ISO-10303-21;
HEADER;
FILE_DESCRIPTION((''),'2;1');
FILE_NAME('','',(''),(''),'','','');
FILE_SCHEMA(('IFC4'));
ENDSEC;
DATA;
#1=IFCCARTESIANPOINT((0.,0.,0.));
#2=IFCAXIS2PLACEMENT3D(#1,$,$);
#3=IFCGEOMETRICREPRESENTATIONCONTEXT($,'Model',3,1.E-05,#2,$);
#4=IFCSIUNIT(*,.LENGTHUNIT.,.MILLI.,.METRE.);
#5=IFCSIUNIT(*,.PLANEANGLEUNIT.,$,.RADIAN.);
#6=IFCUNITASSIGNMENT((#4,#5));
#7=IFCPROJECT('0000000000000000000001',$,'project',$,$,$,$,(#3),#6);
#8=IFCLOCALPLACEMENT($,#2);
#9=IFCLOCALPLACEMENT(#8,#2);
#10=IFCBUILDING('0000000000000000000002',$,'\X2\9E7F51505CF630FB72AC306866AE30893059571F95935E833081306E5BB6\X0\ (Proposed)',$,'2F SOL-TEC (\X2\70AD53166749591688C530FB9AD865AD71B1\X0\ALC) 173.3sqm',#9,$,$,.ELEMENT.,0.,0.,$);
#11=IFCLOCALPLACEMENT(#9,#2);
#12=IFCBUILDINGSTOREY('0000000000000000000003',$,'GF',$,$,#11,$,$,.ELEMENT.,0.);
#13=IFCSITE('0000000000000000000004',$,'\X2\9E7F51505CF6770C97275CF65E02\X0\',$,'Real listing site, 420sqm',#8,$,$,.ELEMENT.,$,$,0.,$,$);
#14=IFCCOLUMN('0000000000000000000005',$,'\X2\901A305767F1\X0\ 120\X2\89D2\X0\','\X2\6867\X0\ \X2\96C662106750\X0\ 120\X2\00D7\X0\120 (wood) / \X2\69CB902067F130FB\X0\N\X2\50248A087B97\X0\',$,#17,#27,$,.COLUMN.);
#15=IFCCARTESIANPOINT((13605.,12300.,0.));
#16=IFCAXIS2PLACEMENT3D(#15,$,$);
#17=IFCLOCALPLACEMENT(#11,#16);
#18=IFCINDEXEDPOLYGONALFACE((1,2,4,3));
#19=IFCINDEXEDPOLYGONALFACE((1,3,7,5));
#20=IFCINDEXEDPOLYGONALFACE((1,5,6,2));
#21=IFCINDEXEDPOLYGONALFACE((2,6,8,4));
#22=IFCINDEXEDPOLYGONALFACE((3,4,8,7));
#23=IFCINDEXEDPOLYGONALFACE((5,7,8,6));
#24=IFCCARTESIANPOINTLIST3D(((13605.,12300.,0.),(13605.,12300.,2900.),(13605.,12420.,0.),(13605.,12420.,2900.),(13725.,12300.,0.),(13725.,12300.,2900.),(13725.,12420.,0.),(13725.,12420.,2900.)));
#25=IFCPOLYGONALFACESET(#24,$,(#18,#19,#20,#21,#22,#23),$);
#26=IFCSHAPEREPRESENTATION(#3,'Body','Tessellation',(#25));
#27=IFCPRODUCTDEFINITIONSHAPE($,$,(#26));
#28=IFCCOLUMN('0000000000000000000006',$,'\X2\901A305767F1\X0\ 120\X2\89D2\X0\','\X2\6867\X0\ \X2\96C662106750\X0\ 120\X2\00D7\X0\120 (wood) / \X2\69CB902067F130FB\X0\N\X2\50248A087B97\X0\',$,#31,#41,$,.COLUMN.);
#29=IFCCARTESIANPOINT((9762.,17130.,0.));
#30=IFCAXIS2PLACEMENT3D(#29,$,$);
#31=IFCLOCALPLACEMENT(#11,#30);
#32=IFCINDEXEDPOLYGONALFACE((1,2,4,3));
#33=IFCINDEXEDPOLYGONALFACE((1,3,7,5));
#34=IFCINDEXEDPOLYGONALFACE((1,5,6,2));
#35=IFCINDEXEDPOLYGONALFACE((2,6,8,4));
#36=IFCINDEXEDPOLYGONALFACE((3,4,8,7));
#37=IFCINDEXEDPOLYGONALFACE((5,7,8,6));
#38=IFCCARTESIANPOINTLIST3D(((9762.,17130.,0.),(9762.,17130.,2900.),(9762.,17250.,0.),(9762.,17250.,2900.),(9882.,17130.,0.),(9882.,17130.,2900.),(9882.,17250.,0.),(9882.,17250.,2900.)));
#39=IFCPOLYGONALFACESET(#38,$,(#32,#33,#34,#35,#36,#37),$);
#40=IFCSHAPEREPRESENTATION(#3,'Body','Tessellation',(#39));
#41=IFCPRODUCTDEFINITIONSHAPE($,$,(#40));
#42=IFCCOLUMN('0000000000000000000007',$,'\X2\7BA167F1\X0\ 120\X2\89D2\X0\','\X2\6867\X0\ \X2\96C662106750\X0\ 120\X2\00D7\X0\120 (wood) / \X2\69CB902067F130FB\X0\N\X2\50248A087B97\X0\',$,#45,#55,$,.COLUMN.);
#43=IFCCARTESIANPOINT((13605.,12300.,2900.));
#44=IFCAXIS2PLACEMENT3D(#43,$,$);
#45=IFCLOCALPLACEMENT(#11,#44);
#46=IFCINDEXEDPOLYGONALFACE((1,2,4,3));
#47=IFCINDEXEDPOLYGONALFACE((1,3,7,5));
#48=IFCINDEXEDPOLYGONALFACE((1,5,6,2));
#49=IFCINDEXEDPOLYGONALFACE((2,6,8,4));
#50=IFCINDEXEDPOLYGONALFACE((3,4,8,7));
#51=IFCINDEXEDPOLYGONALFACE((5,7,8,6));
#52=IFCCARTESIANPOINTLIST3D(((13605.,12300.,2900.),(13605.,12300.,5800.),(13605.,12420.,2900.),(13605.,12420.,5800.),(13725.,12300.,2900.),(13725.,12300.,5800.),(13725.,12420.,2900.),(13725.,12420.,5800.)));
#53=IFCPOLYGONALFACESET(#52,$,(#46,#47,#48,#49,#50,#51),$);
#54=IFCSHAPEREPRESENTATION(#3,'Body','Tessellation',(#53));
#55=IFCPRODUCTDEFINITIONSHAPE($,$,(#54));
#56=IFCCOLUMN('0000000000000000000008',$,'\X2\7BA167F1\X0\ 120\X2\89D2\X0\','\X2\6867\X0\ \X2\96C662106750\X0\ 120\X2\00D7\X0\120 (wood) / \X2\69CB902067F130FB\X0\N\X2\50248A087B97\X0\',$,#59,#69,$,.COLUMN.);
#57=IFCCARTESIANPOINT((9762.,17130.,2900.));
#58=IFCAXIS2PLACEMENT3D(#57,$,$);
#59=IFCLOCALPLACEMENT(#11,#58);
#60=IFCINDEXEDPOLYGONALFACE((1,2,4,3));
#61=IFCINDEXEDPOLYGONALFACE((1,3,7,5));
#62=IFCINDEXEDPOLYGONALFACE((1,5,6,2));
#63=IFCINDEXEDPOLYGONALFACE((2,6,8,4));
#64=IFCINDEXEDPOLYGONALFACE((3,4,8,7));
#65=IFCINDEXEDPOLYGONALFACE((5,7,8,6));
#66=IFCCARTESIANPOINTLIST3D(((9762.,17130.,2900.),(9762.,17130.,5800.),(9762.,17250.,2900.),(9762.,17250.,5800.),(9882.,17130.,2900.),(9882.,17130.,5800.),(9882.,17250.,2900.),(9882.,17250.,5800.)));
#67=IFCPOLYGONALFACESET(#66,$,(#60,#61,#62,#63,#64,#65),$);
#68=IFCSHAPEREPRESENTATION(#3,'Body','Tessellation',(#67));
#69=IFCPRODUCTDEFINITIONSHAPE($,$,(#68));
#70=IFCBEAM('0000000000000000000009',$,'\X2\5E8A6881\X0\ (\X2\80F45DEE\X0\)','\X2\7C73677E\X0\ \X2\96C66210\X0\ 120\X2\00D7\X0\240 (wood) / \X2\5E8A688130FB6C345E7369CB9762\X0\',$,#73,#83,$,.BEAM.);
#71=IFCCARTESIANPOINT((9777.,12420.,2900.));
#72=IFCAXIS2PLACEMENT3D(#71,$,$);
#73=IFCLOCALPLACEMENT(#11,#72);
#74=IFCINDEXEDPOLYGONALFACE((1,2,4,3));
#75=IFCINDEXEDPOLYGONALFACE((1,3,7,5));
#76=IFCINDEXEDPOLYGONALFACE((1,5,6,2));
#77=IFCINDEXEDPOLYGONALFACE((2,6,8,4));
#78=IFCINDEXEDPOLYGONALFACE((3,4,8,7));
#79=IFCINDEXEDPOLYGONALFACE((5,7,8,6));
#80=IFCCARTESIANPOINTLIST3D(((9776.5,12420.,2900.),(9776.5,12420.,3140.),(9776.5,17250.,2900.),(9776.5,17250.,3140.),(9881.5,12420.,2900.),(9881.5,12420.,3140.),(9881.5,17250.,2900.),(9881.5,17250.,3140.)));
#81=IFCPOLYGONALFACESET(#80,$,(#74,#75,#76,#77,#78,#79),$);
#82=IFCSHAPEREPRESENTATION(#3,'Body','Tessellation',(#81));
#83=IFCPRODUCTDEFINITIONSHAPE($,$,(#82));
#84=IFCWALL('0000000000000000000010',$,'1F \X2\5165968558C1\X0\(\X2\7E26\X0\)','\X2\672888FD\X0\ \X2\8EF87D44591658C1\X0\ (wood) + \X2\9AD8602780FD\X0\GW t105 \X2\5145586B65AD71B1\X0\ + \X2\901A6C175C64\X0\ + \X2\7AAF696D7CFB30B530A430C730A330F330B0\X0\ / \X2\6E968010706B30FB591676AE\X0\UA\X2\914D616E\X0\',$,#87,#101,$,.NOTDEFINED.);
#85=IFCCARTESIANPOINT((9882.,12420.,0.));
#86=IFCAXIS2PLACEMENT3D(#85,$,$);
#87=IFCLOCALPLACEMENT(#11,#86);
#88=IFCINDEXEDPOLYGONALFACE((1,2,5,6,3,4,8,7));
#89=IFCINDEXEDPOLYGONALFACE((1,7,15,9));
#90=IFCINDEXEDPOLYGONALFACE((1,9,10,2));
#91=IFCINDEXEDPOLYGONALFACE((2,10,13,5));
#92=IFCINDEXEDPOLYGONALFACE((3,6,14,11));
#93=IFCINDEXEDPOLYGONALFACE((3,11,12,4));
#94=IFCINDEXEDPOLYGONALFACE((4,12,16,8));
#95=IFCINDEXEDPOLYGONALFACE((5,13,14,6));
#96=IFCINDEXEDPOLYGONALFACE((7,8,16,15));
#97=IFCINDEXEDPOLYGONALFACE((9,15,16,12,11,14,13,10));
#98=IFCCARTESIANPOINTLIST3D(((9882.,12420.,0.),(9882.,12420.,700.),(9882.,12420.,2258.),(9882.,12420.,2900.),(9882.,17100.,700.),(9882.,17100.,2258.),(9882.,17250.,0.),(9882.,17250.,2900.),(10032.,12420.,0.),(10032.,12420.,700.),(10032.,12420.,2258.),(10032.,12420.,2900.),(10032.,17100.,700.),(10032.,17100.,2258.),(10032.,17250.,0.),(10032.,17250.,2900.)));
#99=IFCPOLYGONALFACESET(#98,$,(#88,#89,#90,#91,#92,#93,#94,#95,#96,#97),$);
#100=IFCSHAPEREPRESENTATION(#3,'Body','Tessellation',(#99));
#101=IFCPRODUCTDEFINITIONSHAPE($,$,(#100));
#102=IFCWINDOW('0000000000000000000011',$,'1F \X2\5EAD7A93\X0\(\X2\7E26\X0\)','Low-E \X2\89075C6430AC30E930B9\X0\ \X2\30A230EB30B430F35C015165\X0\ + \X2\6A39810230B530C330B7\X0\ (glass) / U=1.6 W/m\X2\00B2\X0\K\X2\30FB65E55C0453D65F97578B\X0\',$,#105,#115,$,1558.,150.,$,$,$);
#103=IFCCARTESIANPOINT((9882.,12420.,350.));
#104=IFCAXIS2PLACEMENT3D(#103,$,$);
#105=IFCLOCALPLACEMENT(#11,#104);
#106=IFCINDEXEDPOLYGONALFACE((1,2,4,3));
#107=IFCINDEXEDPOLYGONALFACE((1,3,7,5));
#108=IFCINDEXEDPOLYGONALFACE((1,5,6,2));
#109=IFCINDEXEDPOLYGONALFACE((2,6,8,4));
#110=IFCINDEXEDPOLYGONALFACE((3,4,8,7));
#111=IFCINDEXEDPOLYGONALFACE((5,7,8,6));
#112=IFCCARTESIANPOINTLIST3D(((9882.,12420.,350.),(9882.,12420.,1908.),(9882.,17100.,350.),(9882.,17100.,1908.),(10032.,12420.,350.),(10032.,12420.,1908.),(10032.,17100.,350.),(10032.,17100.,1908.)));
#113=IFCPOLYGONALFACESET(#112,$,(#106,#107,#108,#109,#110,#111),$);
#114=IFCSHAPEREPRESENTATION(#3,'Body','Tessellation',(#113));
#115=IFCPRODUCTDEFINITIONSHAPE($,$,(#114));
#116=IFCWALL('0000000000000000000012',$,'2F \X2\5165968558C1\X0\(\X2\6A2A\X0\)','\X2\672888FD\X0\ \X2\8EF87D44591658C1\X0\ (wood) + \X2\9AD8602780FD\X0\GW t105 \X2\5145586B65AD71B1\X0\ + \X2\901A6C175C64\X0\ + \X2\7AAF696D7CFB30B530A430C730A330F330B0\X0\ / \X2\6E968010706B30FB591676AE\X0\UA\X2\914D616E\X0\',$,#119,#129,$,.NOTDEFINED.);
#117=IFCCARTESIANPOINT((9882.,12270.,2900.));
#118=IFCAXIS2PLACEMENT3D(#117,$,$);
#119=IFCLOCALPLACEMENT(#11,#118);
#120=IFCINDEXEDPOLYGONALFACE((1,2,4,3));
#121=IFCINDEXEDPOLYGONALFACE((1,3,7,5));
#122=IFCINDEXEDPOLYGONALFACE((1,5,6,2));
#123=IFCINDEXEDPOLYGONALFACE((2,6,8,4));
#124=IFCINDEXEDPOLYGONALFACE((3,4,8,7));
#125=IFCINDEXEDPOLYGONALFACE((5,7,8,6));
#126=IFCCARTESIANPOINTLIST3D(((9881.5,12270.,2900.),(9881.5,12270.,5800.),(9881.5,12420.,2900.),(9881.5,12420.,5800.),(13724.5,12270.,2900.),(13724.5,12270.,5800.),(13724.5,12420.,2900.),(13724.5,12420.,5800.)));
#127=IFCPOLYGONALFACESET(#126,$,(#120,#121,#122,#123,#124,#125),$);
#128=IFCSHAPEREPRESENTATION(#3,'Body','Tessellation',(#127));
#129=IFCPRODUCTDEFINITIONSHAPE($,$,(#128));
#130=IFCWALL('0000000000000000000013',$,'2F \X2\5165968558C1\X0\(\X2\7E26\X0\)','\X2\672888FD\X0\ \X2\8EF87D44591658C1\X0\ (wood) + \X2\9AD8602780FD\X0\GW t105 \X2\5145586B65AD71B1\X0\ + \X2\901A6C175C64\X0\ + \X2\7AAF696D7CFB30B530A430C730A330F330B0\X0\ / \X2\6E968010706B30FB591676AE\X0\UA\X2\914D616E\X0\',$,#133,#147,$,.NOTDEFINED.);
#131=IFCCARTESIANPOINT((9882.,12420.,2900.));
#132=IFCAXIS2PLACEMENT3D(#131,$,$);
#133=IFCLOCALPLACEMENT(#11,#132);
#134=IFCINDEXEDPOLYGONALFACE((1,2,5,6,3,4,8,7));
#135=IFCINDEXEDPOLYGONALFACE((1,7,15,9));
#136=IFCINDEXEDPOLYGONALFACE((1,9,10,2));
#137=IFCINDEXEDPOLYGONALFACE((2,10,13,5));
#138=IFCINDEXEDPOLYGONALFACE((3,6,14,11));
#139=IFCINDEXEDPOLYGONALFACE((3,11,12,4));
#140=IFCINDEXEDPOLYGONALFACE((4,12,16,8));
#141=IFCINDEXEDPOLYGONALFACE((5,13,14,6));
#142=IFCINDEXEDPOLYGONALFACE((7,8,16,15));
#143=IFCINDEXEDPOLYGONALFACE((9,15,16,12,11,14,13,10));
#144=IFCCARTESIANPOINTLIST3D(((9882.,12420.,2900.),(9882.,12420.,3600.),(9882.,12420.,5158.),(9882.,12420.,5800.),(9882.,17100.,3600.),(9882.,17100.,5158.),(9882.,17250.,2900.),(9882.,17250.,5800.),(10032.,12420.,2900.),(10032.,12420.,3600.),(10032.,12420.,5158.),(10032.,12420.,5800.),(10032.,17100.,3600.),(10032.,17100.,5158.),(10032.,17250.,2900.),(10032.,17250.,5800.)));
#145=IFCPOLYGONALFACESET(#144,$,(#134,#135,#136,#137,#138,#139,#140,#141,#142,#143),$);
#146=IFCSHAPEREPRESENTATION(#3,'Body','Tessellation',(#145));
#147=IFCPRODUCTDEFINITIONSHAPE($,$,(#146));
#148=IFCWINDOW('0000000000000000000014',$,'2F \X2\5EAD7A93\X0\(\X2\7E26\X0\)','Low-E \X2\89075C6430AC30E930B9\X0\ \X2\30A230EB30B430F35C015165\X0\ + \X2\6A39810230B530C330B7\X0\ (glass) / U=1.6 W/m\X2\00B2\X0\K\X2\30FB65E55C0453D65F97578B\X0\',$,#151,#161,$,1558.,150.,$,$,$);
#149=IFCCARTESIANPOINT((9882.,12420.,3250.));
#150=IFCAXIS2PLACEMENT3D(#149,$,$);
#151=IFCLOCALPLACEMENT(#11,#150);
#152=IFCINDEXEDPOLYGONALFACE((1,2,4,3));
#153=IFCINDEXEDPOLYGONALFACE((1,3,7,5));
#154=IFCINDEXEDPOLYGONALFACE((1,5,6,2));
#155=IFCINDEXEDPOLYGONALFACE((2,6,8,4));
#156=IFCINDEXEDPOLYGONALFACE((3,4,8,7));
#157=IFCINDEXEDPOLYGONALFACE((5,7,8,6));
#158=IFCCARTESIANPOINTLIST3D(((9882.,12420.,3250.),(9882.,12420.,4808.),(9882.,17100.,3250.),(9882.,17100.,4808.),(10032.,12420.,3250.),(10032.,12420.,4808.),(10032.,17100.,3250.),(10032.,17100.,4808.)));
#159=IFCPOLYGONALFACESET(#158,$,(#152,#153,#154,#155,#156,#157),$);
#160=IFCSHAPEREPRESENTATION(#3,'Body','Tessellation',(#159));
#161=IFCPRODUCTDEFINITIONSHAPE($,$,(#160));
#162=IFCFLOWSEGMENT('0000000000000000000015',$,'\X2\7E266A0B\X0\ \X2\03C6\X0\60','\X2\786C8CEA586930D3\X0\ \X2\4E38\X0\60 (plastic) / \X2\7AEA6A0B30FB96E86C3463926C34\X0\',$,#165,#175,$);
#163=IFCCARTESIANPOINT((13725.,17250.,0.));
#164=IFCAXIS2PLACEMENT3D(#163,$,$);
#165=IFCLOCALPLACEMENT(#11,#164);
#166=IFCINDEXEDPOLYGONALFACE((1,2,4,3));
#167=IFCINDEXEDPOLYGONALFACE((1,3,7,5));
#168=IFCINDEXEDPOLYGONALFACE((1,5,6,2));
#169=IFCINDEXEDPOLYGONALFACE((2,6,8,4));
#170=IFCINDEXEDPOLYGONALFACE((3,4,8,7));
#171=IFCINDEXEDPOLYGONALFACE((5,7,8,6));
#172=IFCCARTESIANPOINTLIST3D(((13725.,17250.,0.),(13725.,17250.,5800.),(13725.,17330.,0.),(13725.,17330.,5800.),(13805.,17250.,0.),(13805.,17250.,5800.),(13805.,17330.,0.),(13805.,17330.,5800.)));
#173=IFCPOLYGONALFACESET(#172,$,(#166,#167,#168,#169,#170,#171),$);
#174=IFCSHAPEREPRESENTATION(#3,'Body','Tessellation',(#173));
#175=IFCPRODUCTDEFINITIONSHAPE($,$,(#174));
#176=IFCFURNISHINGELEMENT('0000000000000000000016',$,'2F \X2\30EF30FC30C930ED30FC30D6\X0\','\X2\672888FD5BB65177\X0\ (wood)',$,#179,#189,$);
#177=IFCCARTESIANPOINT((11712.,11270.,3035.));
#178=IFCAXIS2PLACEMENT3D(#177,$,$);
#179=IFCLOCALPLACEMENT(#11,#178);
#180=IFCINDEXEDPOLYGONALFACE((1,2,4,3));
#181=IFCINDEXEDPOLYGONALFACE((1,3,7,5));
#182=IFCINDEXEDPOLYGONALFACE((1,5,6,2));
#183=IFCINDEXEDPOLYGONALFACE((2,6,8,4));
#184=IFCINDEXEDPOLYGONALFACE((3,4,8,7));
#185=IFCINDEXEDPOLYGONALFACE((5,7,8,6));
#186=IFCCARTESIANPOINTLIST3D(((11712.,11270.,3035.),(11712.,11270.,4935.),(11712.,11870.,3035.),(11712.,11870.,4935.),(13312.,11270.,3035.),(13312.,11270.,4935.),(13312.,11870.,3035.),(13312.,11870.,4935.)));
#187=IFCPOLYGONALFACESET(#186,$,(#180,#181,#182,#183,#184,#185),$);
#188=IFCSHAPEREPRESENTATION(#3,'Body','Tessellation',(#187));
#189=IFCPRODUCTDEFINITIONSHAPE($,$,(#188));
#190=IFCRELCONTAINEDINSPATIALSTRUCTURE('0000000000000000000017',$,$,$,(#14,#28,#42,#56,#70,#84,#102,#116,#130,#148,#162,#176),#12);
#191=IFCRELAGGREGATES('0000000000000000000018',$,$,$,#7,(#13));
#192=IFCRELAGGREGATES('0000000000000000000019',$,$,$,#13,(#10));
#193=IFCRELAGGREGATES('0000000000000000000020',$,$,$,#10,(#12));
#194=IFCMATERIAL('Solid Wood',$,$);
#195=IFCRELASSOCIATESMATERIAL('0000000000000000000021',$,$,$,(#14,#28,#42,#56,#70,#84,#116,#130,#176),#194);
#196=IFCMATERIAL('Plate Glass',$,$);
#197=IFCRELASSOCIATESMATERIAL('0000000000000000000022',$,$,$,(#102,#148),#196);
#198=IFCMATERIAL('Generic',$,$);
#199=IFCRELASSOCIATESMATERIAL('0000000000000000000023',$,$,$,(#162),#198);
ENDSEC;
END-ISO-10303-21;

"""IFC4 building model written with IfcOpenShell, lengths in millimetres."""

from ifc_helpers import new_model, si_unit, frame, frame_2d, origin, place, context, project, spatial, rectangle, extrude, material, element, fill, save


model = new_model("IFC4")

# Units and contexts
model_context = context("Model", 3, precision=1e-05, world=origin())
ifc_project = project(units=[si_unit("LENGTHUNIT", "METRE", prefix="MILLI"), si_unit("PLANEANGLEUNIT", "RADIAN")], contexts=[model_context])

# Site, building, storey
site_placement = place(None, origin())
site = spatial("IfcSite", under=ifc_project, at=site_placement, Name="鹿児島県霧島市", ObjectType="Real listing site, 420sqm", CompositionType="ELEMENT", RefElevation=0.0)
building_placement = place(site_placement, origin())
building = spatial("IfcBuilding", under=site, at=building_placement, Name="鹿児島・犬と暮らす土間広めの家 (Proposed)", ObjectType="2F SOL-TEC (炭化杉外装・高断熱ALC) 173.3sqm", CompositionType="ELEMENT", ElevationOfRefHeight=0.0, ElevationOfTerrain=0.0)
storey_placement = place(building_placement, origin())
storey = spatial("IfcBuildingStorey", under=building, at=storey_placement, Name="GF", CompositionType="ELEMENT", Elevation=0.0)

# Columns
ifc_material_1 = material(Name="Solid Wood")
column_1_placement = place(storey_placement, frame((13605.0, 12300.0, 0.0)))
element("IfcColumn", 1, at=column_1_placement, inside=storey, material=ifc_material_1, Name="通し柱 120角", Description="桧 集成材 120×120 (wood) / 構造柱・N値計算", PredefinedType="COLUMN", context=model_context, shape_type="SweptSolid", body=[
    extrude(rectangle(XDim=120.0, YDim=120.0, at=frame_2d((60.0, 60.0))), frame((13605.0, 12300.0, 0.0)), (0.0, 0.0, 1.0), 2900.0),
])
column_2_placement = place(storey_placement, frame((9762.0, 17130.0, 0.0)))
element("IfcColumn", 2, at=column_2_placement, inside=storey, material=ifc_material_1, Name="通し柱 120角", Description="桧 集成材 120×120 (wood) / 構造柱・N値計算", PredefinedType="COLUMN", context=model_context, shape_type="SweptSolid", body=[
    extrude(rectangle(XDim=120.0, YDim=120.0, at=frame_2d((60.0, 60.0))), frame((9762.0, 17130.0, 0.0)), (0.0, 0.0, 1.0), 2900.0),
])
column_3_placement = place(storey_placement, frame((13605.0, 12300.0, 2900.0)))
element("IfcColumn", 3, at=column_3_placement, inside=storey, material=ifc_material_1, Name="管柱 120角", Description="桧 集成材 120×120 (wood) / 構造柱・N値計算", PredefinedType="COLUMN", context=model_context, shape_type="SweptSolid", body=[
    extrude(rectangle(XDim=120.0, YDim=120.0, at=frame_2d((60.0, 60.0))), frame((13605.0, 12300.0, 2900.0)), (0.0, 0.0, 1.0), 2900.0),
])
column_4_placement = place(storey_placement, frame((9762.0, 17130.0, 2900.0)))
element("IfcColumn", 4, at=column_4_placement, inside=storey, material=ifc_material_1, Name="管柱 120角", Description="桧 集成材 120×120 (wood) / 構造柱・N値計算", PredefinedType="COLUMN", context=model_context, shape_type="SweptSolid", body=[
    extrude(rectangle(XDim=120.0, YDim=120.0, at=frame_2d((60.0, 60.0))), frame((9762.0, 17130.0, 2900.0)), (0.0, 0.0, 1.0), 2900.0),
])

# Beam
beam_1_placement = place(storey_placement, frame((9777.0, 12420.0, 2900.0)))
element("IfcBeam", 5, at=beam_1_placement, inside=storey, material=ifc_material_1, Name="床梁 (胴差)", Description="米松 集成 120×240 (wood) / 床梁・水平構面", PredefinedType="BEAM", context=model_context, shape_type="SweptSolid", body=[
    extrude(rectangle(XDim=105.0, YDim=4830.0, at=frame_2d((52.0, 2415.0))), frame((9777.0, 12420.0, 2900.0)), (0.0, 0.0, 1.0), 240.0),
])

# Wall, opening, window
wall_1_placement = place(storey_placement, frame((9882.0, 12420.0, 0.0)))
wall_1 = element("IfcWall", 6, at=wall_1_placement, inside=storey, material=ifc_material_1, Name="1F 入隅壁(縦)", Description="木製 軸組外壁 (wood) + 高性能GW t105 充填断熱 + 通気層 + 窯業系サイディング / 準耐火・外皮UA配慮", PredefinedType="NOTDEFINED", context=model_context, shape_type="SweptSolid", body=[
    extrude(rectangle(XDim=150.0, YDim=4830.0, at=frame_2d((75.0, 2415.0))), frame((9882.0, 12420.0, 0.0)), (0.0, 0.0, 1.0), 2900.0),
])
opening_1_placement = place(storey_placement, frame((9882.0, 12420.0, 350.0)))
opening_1 = element("IfcOpeningElement", 7, at=opening_1_placement, cuts=wall_1, PredefinedType="NOTDEFINED", context=model_context, shape_type="SweptSolid", body=[
    extrude(rectangle(XDim=150.0, YDim=4680.0, at=frame_2d((75.0, 2340.0))), frame((9882.0, 12420.0, 350.0)), (0.0, 0.0, 1.0), 1558.0),
])
ifc_material_2 = material(Name="Plate Glass")
window_1_placement = place(storey_placement, frame((9882.0, 12420.0, 350.0)))
window_1 = element("IfcWindow", 8, at=window_1_placement, inside=storey, material=ifc_material_2, Name="1F 庭窓(縦)", Description="Low-E 複層ガラス アルゴン封入 + 樹脂サッシ (glass) / U=1.6 W/m²K・日射取得型", OverallHeight=1558.0, OverallWidth=150.0, context=model_context, shape_type="SweptSolid", body=[
    extrude(rectangle(XDim=150.0, YDim=4680.0, at=frame_2d((75.0, 2340.0))), frame((9882.0, 12420.0, 350.0)), (0.0, 0.0, 1.0), 1558.0),
])
fill(opening_1, window_1)

# Wall
wall_2_placement = place(storey_placement, frame((9882.0, 12270.0, 2900.0)))
element("IfcWall", 9, at=wall_2_placement, inside=storey, material=ifc_material_1, Name="2F 入隅壁(横)", Description="木製 軸組外壁 (wood) + 高性能GW t105 充填断熱 + 通気層 + 窯業系サイディング / 準耐火・外皮UA配慮", PredefinedType="NOTDEFINED", context=model_context, shape_type="SweptSolid", body=[
    extrude(rectangle(XDim=3843.0, YDim=150.0, at=frame_2d((1921.0, 75.0))), frame((9882.0, 12270.0, 2900.0)), (0.0, 0.0, 1.0), 2900.0),
])

# Wall, opening, window
wall_3_placement = place(storey_placement, frame((9882.0, 12420.0, 2900.0)))
wall_3 = element("IfcWall", 10, at=wall_3_placement, inside=storey, material=ifc_material_1, Name="2F 入隅壁(縦)", Description="木製 軸組外壁 (wood) + 高性能GW t105 充填断熱 + 通気層 + 窯業系サイディング / 準耐火・外皮UA配慮", PredefinedType="NOTDEFINED", context=model_context, shape_type="SweptSolid", body=[
    extrude(rectangle(XDim=150.0, YDim=4830.0, at=frame_2d((75.0, 2415.0))), frame((9882.0, 12420.0, 2900.0)), (0.0, 0.0, 1.0), 2900.0),
])
opening_2_placement = place(storey_placement, frame((9882.0, 12420.0, 3250.0)))
opening_2 = element("IfcOpeningElement", 11, at=opening_2_placement, cuts=wall_3, PredefinedType="NOTDEFINED", context=model_context, shape_type="SweptSolid", body=[
    extrude(rectangle(XDim=150.0, YDim=4680.0, at=frame_2d((75.0, 2340.0))), frame((9882.0, 12420.0, 3250.0)), (0.0, 0.0, 1.0), 1558.0),
])
window_2_placement = place(storey_placement, frame((9882.0, 12420.0, 3250.0)))
window_2 = element("IfcWindow", 12, at=window_2_placement, inside=storey, material=ifc_material_2, Name="2F 庭窓(縦)", Description="Low-E 複層ガラス アルゴン封入 + 樹脂サッシ (glass) / U=1.6 W/m²K・日射取得型", OverallHeight=1558.0, OverallWidth=150.0, context=model_context, shape_type="SweptSolid", body=[
    extrude(rectangle(XDim=150.0, YDim=4680.0, at=frame_2d((75.0, 2340.0))), frame((9882.0, 12420.0, 3250.0)), (0.0, 0.0, 1.0), 1558.0),
])
fill(opening_2, window_2)

# Flow segment
ifc_material_3 = material(Name="Generic")
flow_segment_placement = place(storey_placement, frame((13725.0, 17250.0, 0.0)))
element("IfcFlowSegment", 13, at=flow_segment_placement, inside=storey, material=ifc_material_3, Name="縦樋 φ60", Description="硬質塩ビ 丸60 (plastic) / 竪樋・雨水排水", context=model_context, shape_type="SweptSolid", body=[
    extrude(rectangle(XDim=80.0, YDim=80.0, at=frame_2d((40.0, 40.0))), frame((13725.0, 17250.0, 0.0)), (0.0, 0.0, 1.0), 5800.0),
])

# Furnishing element
furnishing_placement = place(storey_placement, frame((11712.0, 11270.0, 3035.0)))
element("IfcFurnishingElement", 14, at=furnishing_placement, inside=storey, material=ifc_material_1, Name="2F ワードローブ", Description="木製家具 (wood)", context=model_context, shape_type="SweptSolid", body=[
    extrude(rectangle(XDim=1600.0, YDim=600.0, at=frame_2d((800.0, 300.0))), frame((11712.0, 11270.0, 3035.0)), (0.0, 0.0, 1.0), 1900.0),
])

save(model, "model.ifc")
